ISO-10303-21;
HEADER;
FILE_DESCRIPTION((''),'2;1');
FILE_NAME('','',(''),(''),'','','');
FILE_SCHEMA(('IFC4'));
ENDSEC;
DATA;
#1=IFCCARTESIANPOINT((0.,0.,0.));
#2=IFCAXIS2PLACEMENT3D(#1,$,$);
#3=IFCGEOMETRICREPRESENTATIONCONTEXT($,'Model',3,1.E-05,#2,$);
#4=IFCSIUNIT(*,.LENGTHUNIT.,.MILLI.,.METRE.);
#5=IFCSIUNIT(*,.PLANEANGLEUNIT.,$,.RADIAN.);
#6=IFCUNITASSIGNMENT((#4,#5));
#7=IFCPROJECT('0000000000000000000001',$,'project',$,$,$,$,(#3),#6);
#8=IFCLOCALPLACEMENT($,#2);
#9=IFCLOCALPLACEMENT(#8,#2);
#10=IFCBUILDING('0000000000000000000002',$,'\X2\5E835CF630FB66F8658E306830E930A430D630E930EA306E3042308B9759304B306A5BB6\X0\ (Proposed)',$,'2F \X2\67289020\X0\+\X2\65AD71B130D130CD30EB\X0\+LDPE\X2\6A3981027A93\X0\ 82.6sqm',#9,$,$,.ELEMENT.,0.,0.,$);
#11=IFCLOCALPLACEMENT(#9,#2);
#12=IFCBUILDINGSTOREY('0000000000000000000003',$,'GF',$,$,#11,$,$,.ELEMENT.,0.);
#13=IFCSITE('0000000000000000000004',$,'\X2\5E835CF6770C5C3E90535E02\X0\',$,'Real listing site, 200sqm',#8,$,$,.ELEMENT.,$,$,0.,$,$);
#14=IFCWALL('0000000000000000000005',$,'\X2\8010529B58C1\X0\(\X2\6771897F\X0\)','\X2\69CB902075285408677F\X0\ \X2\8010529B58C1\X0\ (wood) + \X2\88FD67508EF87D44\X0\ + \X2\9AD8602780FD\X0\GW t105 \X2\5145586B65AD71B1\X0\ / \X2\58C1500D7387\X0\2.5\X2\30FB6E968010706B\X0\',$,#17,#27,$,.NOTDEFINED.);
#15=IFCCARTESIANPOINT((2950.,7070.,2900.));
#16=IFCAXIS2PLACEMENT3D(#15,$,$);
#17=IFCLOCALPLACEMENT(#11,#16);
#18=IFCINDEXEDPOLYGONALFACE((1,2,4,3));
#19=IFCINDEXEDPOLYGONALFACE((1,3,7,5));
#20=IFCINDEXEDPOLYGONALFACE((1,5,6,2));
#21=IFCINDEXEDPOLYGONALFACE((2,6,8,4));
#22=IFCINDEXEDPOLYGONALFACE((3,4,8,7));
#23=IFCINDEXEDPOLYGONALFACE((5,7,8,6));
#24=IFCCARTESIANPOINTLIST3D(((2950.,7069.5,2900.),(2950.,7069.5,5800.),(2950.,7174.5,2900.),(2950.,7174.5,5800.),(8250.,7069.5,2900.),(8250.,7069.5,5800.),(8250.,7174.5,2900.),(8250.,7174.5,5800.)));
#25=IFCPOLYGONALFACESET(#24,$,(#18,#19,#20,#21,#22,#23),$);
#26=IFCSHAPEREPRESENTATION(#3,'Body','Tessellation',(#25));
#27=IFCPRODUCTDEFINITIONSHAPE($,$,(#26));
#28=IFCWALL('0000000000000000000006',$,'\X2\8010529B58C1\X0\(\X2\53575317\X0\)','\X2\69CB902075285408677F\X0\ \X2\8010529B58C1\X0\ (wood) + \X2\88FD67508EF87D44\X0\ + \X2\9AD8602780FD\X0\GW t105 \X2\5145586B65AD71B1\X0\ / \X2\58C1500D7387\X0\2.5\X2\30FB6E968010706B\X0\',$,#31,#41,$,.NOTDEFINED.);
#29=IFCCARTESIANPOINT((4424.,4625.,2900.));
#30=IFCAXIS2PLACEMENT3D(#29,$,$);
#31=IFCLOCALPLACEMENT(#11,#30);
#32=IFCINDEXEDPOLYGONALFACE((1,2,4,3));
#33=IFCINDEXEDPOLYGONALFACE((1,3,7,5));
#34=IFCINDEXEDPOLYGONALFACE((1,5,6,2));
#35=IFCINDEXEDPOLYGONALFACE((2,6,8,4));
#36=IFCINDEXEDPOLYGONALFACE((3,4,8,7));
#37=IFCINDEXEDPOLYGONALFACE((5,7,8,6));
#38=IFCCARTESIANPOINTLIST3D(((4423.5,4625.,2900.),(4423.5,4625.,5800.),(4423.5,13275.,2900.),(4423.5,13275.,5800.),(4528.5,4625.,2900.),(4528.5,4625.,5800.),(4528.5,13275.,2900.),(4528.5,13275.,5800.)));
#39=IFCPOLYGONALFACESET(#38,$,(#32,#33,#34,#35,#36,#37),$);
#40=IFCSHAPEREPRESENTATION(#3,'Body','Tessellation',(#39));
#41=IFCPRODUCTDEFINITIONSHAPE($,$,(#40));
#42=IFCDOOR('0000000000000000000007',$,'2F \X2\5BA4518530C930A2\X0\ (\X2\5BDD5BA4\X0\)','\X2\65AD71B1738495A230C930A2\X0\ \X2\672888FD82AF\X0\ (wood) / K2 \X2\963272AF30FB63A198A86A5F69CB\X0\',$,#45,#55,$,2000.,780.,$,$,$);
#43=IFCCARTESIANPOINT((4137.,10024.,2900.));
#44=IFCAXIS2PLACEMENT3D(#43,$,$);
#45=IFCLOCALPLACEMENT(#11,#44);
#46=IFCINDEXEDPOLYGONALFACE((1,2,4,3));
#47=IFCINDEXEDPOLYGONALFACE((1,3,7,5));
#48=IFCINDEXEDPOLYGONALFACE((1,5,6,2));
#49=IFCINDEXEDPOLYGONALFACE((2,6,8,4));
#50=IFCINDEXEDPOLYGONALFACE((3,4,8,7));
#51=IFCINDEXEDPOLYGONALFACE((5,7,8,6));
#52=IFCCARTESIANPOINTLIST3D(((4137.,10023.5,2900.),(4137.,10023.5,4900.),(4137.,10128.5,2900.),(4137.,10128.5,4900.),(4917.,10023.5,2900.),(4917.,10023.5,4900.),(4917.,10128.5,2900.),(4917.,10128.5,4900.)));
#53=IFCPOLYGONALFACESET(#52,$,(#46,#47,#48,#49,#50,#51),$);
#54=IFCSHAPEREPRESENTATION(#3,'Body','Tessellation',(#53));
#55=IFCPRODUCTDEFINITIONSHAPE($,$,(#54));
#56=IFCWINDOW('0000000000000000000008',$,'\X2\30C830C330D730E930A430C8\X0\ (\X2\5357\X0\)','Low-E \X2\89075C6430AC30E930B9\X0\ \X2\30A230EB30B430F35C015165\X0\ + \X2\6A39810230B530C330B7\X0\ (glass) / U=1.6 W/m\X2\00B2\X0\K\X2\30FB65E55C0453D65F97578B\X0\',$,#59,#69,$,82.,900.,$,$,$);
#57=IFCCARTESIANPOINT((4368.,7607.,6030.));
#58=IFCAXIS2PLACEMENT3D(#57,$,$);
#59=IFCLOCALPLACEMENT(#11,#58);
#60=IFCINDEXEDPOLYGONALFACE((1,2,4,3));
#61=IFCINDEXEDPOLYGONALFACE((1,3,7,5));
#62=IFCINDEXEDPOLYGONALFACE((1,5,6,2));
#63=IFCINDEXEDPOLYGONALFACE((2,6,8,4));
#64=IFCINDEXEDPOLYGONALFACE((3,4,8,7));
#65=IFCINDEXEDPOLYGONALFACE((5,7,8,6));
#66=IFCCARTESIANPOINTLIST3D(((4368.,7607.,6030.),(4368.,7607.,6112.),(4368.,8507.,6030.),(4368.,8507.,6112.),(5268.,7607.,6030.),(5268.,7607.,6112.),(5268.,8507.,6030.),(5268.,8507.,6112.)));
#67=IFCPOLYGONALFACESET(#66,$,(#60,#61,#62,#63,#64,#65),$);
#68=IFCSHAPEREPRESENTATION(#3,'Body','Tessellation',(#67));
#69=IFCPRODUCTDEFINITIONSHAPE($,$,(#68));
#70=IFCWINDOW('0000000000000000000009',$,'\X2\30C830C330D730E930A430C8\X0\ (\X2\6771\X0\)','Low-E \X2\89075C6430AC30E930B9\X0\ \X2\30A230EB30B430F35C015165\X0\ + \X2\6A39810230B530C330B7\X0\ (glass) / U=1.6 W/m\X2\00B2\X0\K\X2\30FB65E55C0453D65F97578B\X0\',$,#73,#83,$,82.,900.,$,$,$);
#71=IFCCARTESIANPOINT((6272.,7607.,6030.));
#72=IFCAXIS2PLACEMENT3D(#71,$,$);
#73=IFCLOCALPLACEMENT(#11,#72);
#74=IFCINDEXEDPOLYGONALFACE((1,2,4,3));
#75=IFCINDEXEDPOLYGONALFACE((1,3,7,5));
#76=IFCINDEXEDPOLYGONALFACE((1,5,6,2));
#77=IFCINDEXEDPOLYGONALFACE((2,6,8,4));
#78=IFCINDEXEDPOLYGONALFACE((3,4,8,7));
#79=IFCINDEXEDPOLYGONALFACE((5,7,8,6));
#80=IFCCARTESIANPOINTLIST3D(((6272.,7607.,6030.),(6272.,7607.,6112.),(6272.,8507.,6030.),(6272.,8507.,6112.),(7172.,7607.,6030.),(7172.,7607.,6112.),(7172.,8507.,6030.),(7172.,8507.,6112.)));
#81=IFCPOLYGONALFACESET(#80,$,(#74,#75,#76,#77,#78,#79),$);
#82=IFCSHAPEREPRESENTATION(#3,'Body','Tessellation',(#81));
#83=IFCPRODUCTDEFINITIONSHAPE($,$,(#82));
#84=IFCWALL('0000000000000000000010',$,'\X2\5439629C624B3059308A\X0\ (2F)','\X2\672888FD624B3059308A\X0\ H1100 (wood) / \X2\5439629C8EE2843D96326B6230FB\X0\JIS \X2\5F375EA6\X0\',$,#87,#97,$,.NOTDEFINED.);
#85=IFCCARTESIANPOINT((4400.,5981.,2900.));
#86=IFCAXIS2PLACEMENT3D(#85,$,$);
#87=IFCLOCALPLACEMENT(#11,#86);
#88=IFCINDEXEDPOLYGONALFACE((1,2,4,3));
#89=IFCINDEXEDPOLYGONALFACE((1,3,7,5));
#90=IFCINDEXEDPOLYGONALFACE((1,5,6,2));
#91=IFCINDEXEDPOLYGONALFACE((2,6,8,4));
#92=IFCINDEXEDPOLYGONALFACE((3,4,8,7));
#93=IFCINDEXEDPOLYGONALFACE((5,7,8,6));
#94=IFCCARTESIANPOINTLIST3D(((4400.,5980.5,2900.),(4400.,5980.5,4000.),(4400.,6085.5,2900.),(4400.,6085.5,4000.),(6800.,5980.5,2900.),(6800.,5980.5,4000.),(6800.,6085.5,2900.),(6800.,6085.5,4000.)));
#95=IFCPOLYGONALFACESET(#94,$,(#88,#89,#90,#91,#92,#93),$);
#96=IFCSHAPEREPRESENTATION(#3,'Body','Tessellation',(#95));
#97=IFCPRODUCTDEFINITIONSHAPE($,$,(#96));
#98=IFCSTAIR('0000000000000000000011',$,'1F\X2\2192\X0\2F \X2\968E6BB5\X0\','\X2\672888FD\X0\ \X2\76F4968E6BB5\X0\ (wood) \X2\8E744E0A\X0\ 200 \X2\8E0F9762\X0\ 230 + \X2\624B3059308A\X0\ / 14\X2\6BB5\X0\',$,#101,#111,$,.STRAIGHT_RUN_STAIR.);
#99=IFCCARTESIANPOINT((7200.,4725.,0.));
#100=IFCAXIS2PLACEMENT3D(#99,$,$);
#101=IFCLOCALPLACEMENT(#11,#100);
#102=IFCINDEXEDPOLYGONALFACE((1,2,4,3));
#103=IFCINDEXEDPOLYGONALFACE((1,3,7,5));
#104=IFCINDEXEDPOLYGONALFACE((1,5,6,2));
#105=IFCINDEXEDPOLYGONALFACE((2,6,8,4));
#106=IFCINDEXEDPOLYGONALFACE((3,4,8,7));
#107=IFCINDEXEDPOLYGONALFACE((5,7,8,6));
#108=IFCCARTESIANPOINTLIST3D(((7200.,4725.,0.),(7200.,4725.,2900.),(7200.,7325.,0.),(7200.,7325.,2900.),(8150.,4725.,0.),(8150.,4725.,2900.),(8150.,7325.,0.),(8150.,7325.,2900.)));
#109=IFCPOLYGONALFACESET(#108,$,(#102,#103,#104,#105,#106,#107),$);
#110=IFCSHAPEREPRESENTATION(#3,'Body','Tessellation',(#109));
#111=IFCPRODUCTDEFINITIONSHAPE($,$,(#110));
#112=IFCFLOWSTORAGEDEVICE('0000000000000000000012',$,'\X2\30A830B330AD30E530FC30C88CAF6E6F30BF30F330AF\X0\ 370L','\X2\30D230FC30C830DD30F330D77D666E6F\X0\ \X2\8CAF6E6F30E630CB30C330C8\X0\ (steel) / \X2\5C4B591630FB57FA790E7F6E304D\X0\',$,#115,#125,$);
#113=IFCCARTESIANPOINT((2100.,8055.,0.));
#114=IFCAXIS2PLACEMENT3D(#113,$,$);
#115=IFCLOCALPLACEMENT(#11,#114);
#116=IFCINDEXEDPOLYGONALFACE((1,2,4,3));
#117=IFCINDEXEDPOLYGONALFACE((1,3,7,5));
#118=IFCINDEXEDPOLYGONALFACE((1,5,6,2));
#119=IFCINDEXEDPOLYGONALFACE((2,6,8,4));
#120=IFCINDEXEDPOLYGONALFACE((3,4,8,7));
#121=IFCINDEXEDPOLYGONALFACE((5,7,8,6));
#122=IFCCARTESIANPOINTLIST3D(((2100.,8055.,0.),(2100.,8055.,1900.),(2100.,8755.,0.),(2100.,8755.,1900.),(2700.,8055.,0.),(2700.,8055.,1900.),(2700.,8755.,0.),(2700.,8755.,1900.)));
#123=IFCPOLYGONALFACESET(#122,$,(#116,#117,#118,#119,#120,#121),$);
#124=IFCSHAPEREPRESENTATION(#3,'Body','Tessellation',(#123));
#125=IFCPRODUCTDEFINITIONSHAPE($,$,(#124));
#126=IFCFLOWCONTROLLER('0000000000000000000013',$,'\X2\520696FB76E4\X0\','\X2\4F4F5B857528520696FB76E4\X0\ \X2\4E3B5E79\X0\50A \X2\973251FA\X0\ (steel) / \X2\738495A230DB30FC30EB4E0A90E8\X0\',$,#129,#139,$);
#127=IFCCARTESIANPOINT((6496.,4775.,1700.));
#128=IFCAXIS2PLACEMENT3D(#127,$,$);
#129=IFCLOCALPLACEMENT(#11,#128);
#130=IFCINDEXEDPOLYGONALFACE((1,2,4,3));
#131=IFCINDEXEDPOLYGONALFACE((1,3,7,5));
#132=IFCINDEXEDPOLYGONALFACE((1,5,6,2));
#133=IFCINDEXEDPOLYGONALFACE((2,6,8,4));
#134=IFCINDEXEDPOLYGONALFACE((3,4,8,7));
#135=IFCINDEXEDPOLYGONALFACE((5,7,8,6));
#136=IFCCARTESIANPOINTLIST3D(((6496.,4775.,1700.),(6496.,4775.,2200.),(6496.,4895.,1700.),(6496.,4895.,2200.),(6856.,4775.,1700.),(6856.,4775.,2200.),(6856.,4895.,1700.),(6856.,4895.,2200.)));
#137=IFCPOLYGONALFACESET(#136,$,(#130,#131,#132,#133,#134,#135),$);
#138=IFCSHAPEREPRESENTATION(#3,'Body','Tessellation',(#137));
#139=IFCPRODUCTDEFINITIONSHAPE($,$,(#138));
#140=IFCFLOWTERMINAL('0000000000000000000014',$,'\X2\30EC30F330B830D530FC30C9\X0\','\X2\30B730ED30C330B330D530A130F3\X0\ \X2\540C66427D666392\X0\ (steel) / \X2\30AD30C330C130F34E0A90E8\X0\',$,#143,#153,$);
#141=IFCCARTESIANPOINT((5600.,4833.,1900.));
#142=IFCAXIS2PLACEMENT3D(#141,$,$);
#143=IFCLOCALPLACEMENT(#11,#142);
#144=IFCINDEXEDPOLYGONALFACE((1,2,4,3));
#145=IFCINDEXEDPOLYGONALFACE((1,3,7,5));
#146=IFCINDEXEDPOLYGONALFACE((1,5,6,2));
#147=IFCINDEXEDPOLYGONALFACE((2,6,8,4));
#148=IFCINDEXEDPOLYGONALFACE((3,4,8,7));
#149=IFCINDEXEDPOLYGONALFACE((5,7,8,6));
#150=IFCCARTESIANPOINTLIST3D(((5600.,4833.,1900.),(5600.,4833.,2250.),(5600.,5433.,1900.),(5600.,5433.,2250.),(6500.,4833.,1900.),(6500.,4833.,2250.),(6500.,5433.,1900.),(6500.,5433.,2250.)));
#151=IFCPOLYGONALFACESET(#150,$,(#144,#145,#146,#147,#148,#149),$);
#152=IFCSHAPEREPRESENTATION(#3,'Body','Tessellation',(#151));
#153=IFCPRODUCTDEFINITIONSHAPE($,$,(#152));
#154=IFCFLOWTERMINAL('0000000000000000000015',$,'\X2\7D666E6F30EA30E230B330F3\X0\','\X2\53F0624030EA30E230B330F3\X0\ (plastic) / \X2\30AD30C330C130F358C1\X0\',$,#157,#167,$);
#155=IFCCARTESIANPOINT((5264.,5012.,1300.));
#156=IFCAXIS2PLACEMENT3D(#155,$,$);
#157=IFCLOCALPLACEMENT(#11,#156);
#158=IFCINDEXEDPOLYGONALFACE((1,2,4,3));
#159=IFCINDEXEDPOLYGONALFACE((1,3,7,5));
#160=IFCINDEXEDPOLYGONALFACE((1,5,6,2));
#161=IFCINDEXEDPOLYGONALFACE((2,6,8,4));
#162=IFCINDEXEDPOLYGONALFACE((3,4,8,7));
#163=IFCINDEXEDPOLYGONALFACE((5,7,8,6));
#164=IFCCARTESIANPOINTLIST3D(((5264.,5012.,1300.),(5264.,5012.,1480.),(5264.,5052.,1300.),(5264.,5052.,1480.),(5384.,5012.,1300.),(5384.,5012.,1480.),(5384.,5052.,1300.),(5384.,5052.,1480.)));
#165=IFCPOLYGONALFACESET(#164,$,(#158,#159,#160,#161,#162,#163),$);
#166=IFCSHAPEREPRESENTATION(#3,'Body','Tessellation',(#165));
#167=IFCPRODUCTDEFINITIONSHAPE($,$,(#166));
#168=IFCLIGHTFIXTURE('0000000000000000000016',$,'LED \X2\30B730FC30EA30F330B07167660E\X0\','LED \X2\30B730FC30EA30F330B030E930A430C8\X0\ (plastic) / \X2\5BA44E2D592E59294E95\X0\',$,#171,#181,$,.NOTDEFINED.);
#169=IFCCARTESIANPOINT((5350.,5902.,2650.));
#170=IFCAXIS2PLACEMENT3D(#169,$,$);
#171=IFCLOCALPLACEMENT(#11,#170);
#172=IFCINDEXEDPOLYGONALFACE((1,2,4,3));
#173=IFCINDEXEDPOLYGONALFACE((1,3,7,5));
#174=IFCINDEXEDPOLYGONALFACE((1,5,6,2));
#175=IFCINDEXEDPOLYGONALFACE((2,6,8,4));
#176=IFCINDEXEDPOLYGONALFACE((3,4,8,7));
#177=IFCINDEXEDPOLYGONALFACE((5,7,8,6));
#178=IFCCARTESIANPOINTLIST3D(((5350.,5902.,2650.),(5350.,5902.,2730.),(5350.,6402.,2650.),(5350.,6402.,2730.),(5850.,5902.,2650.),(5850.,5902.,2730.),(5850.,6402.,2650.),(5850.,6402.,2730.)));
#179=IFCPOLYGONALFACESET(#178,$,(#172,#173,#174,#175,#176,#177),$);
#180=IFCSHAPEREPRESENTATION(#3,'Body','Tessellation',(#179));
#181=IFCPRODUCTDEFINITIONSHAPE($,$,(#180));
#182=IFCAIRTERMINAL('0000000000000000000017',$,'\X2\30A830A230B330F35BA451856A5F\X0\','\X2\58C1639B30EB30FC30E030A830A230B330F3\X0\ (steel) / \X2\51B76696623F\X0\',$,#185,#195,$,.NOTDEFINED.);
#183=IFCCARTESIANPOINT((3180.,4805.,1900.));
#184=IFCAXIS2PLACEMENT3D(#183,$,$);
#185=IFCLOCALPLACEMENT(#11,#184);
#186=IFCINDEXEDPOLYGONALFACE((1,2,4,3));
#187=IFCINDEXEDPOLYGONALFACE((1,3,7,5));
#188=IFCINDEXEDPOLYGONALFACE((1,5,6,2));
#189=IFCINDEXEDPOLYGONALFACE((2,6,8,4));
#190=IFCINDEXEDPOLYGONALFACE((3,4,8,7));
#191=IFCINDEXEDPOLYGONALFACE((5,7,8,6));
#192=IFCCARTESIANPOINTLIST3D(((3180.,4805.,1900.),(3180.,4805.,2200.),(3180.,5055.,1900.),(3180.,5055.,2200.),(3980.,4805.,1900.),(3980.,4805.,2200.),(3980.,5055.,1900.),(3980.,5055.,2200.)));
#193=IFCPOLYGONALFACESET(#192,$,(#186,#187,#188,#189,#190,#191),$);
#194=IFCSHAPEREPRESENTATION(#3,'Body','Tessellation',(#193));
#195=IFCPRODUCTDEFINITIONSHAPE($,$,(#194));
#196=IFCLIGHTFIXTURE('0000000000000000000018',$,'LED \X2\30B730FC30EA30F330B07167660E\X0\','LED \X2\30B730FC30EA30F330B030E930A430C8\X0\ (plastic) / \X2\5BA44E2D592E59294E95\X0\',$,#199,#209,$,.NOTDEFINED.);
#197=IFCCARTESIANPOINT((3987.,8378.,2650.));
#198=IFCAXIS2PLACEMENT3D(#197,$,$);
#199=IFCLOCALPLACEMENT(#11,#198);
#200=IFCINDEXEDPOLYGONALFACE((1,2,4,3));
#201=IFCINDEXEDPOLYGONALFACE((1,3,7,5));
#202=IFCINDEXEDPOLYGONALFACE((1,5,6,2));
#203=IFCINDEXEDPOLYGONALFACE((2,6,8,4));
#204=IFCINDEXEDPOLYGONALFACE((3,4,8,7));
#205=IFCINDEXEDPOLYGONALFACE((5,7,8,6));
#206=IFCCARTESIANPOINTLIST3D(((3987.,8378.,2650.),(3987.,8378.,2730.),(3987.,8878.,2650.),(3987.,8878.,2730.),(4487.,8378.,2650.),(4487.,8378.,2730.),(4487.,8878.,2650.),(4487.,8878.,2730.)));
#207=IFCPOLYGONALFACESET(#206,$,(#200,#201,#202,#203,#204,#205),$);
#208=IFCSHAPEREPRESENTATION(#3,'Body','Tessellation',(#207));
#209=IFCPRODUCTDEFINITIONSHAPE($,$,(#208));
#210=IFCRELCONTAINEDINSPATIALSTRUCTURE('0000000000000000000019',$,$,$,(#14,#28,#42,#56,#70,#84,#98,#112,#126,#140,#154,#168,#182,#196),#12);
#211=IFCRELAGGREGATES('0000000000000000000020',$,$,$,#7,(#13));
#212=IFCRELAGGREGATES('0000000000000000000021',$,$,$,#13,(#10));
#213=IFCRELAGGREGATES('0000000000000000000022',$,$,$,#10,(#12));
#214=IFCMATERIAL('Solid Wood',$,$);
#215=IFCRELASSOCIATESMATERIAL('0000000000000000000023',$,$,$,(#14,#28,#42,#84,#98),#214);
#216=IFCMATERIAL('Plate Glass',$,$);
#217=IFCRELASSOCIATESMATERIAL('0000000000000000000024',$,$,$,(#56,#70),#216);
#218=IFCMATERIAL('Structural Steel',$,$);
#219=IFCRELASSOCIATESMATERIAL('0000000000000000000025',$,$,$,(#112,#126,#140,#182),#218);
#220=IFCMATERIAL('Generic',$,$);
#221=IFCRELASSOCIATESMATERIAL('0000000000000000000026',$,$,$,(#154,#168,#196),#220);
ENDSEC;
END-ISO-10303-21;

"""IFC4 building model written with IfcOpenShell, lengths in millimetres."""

from ifc_helpers import new_model, si_unit, frame, frame_2d, origin, place, context, project, spatial, rectangle, extrude, material, element, fill, save


model = new_model("IFC4")

# Units and contexts
model_context = context("Model", 3, precision=1e-05, world=origin())
ifc_project = project(units=[si_unit("LENGTHUNIT", "METRE", prefix="MILLI"), si_unit("PLANEANGLEUNIT", "RADIAN")], contexts=[model_context])

# Site, building, storey
site_placement = place(None, origin())
site = spatial("IfcSite", under=ifc_project, at=site_placement, Name="広島県尾道市", ObjectType="Real listing site, 200sqm", CompositionType="ELEMENT", RefElevation=0.0)
building_placement = place(site_placement, origin())
building = spatial("IfcBuilding", under=site, at=building_placement, Name="広島・書斎とライブラリのある静かな家 (Proposed)", ObjectType="2F 木造+断熱パネル+LDPE樹脂窓 82.6sqm", CompositionType="ELEMENT", ElevationOfRefHeight=0.0, ElevationOfTerrain=0.0)
storey_placement = place(building_placement, origin())
storey = spatial("IfcBuildingStorey", under=building, at=storey_placement, Name="GF", CompositionType="ELEMENT", Elevation=0.0)

# Shared definitions
ifc_material_1 = material(Name="Solid Wood")

# Wall
wall_1_placement = place(storey_placement, frame((2950.0, 7070.0, 2900.0)))
element("IfcWall", 1, at=wall_1_placement, inside=storey, material=ifc_material_1, Name="耐力壁(東西)", Description="構造用合板 耐力壁 (wood) + 製材軸組 + 高性能GW t105 充填断熱 / 壁倍率2.5・準耐火", PredefinedType="NOTDEFINED", context=model_context, shape_type="SweptSolid", body=[
    extrude(rectangle(XDim=5300.0, YDim=105.0, at=frame_2d((2650.0, 52.0))), frame((2950.0, 7070.0, 2900.0)), (0.0, 0.0, 1.0), 2900.0),
])

# Wall, opening, door
wall_2_placement = place(storey_placement, frame((4424.0, 4625.0, 2900.0)))
wall_2 = element("IfcWall", 2, at=wall_2_placement, inside=storey, material=ifc_material_1, Name="耐力壁(南北)", Description="構造用合板 耐力壁 (wood) + 製材軸組 + 高性能GW t105 充填断熱 / 壁倍率2.5・準耐火", PredefinedType="NOTDEFINED", context=model_context, shape_type="SweptSolid", body=[
    extrude(rectangle(XDim=105.0, YDim=8650.0, at=frame_2d((52.0, 4325.0))), frame((4424.0, 4625.0, 2900.0)), (0.0, 0.0, 1.0), 2900.0),
])
opening_placement = place(storey_placement, frame((4137.0, 10024.0, 2900.0)))
opening = element("IfcOpeningElement", 3, at=opening_placement, cuts=wall_2, PredefinedType="NOTDEFINED", context=model_context, shape_type="SweptSolid", body=[
    extrude(rectangle(XDim=780.0, YDim=105.0, at=frame_2d((390.0, 52.0))), frame((4137.0, 10024.0, 2900.0)), (0.0, 0.0, 1.0), 2000.0),
])
door_placement = place(storey_placement, frame((4137.0, 10024.0, 2900.0)))
door = element("IfcDoor", 4, at=door_placement, inside=storey, material=ifc_material_1, Name="2F 室内ドア (寝室)", Description="断熱玄関ドア 木製芯 (wood) / K2 防犯・採風機構", OverallHeight=2000.0, OverallWidth=780.0, context=model_context, shape_type="SweptSolid", body=[
    extrude(rectangle(XDim=780.0, YDim=105.0, at=frame_2d((390.0, 52.0))), frame((4137.0, 10024.0, 2900.0)), (0.0, 0.0, 1.0), 2000.0),
])
fill(opening, door)

# Windows
ifc_material_2 = material(Name="Plate Glass")
window_1_placement = place(storey_placement, frame((4368.0, 7607.0, 6030.0)))
element("IfcWindow", 5, at=window_1_placement, inside=storey, material=ifc_material_2, Name="トップライト (南)", Description="Low-E 複層ガラス アルゴン封入 + 樹脂サッシ (glass) / U=1.6 W/m²K・日射取得型", OverallHeight=82.0, OverallWidth=900.0, context=model_context, shape_type="SweptSolid", body=[
    extrude(rectangle(XDim=900.0, YDim=900.0, at=frame_2d((450.0, 450.0))), frame((4368.0, 7607.0, 6030.0)), (0.0, 0.0, 1.0), 82.0),
])
window_2_placement = place(storey_placement, frame((6272.0, 7607.0, 6030.0)))
element("IfcWindow", 6, at=window_2_placement, inside=storey, material=ifc_material_2, Name="トップライト (東)", Description="Low-E 複層ガラス アルゴン封入 + 樹脂サッシ (glass) / U=1.6 W/m²K・日射取得型", OverallHeight=82.0, OverallWidth=900.0, context=model_context, shape_type="SweptSolid", body=[
    extrude(rectangle(XDim=900.0, YDim=900.0, at=frame_2d((450.0, 450.0))), frame((6272.0, 7607.0, 6030.0)), (0.0, 0.0, 1.0), 82.0),
])

# Wall
wall_3_placement = place(storey_placement, frame((4400.0, 5981.0, 2900.0)))
element("IfcWall", 7, at=wall_3_placement, inside=storey, material=ifc_material_1, Name="吹抜手すり (2F)", Description="木製手すり H1100 (wood) / 吹抜転落防止・JIS 強度", PredefinedType="NOTDEFINED", context=model_context, shape_type="SweptSolid", body=[
    extrude(rectangle(XDim=2400.0, YDim=105.0, at=frame_2d((1200.0, 52.0))), frame((4400.0, 5981.0, 2900.0)), (0.0, 0.0, 1.0), 1100.0),
])

# Stair
stair_placement = place(storey_placement, frame((7200.0, 4725.0, 0.0)))
element("IfcStair", 8, at=stair_placement, inside=storey, material=ifc_material_1, Name="1F→2F 階段", Description="木製 直階段 (wood) 蹴上 200 踏面 230 + 手すり / 14段", PredefinedType="STRAIGHT_RUN_STAIR", context=model_context, shape_type="SweptSolid", body=[
    extrude(rectangle(XDim=950.0, YDim=2600.0, at=frame_2d((475.0, 1300.0))), frame((7200.0, 4725.0, 0.0)), (0.0, 0.0, 1.0), 2900.0),
])

# Flow storage device
ifc_material_3 = material(Name="Structural Steel")
flow_storage_device_placement = place(storey_placement, frame((2100.0, 8055.0, 0.0)))
element("IfcFlowStorageDevice", 9, at=flow_storage_device_placement, inside=storey, material=ifc_material_3, Name="エコキュート貯湯タンク 370L", Description="ヒートポンプ給湯 貯湯ユニット (steel) / 屋外・基礎置き", context=model_context, shape_type="SweptSolid", body=[
    extrude(rectangle(XDim=600.0, YDim=700.0, at=frame_2d((300.0, 350.0))), frame((2100.0, 8055.0, 0.0)), (0.0, 0.0, 1.0), 1900.0),
])

# Flow controller
flow_controller_placement = place(storey_placement, frame((6496.0, 4775.0, 1700.0)))
element("IfcFlowController", 10, at=flow_controller_placement, inside=storey, material=ifc_material_3, Name="分電盤", Description="住宅用分電盤 主幹50A 露出 (steel) / 玄関ホール上部", context=model_context, shape_type="SweptSolid", body=[
    extrude(rectangle(XDim=360.0, YDim=120.0, at=frame_2d((180.0, 60.0))), frame((6496.0, 4775.0, 1700.0)), (0.0, 0.0, 1.0), 500.0),
])

# Flow terminals
flow_terminal_1_placement = place(storey_placement, frame((5600.0, 4833.0, 1900.0)))
element("IfcFlowTerminal", 11, at=flow_terminal_1_placement, inside=storey, material=ifc_material_3, Name="レンジフード", Description="シロッコファン 同時給排 (steel) / キッチン上部", context=model_context, shape_type="SweptSolid", body=[
    extrude(rectangle(XDim=900.0, YDim=600.0, at=frame_2d((450.0, 300.0))), frame((5600.0, 4833.0, 1900.0)), (0.0, 0.0, 1.0), 350.0),
])
ifc_material_4 = material(Name="Generic")
flow_terminal_2_placement = place(storey_placement, frame((5264.0, 5012.0, 1300.0)))
element("IfcFlowTerminal", 12, at=flow_terminal_2_placement, inside=storey, material=ifc_material_4, Name="給湯リモコン", Description="台所リモコン (plastic) / キッチン壁", context=model_context, shape_type="SweptSolid", body=[
    extrude(rectangle(XDim=120.0, YDim=40.0, at=frame_2d((60.0, 20.0))), frame((5264.0, 5012.0, 1300.0)), (0.0, 0.0, 1.0), 180.0),
])

# Light fixture
light_fixture_1_placement = place(storey_placement, frame((5350.0, 5902.0, 2650.0)))
element("IfcLightFixture", 13, at=light_fixture_1_placement, inside=storey, material=ifc_material_4, Name="LED シーリング照明", Description="LED シーリングライト (plastic) / 室中央天井", PredefinedType="NOTDEFINED", context=model_context, shape_type="SweptSolid", body=[
    extrude(rectangle(XDim=500.0, YDim=500.0, at=frame_2d((250.0, 250.0))), frame((5350.0, 5902.0, 2650.0)), (0.0, 0.0, 1.0), 80.0),
])

# Air terminal
air_terminal_1_placement = place(storey_placement, frame((3180.0, 4805.0, 1900.0)))
element("IfcAirTerminal", 14, at=air_terminal_1_placement, inside=storey, material=ifc_material_3, Name="エアコン室内機", Description="壁掛ルームエアコン (steel) / 冷暖房", PredefinedType="NOTDEFINED", context=model_context, shape_type="SweptSolid", body=[
    extrude(rectangle(XDim=800.0, YDim=250.0, at=frame_2d((400.0, 125.0))), frame((3180.0, 4805.0, 1900.0)), (0.0, 0.0, 1.0), 300.0),
])

# Light fixture
light_fixture_2_placement = place(storey_placement, frame((3987.0, 8378.0, 2650.0)))
element("IfcLightFixture", 15, at=light_fixture_2_placement, inside=storey, material=ifc_material_4, Name="LED シーリング照明", Description="LED シーリングライト (plastic) / 室中央天井", PredefinedType="NOTDEFINED", context=model_context, shape_type="SweptSolid", body=[
    extrude(rectangle(XDim=500.0, YDim=500.0, at=frame_2d((250.0, 250.0))), frame((3987.0, 8378.0, 2650.0)), (0.0, 0.0, 1.0), 80.0),
])

save(model, "model.ifc")
